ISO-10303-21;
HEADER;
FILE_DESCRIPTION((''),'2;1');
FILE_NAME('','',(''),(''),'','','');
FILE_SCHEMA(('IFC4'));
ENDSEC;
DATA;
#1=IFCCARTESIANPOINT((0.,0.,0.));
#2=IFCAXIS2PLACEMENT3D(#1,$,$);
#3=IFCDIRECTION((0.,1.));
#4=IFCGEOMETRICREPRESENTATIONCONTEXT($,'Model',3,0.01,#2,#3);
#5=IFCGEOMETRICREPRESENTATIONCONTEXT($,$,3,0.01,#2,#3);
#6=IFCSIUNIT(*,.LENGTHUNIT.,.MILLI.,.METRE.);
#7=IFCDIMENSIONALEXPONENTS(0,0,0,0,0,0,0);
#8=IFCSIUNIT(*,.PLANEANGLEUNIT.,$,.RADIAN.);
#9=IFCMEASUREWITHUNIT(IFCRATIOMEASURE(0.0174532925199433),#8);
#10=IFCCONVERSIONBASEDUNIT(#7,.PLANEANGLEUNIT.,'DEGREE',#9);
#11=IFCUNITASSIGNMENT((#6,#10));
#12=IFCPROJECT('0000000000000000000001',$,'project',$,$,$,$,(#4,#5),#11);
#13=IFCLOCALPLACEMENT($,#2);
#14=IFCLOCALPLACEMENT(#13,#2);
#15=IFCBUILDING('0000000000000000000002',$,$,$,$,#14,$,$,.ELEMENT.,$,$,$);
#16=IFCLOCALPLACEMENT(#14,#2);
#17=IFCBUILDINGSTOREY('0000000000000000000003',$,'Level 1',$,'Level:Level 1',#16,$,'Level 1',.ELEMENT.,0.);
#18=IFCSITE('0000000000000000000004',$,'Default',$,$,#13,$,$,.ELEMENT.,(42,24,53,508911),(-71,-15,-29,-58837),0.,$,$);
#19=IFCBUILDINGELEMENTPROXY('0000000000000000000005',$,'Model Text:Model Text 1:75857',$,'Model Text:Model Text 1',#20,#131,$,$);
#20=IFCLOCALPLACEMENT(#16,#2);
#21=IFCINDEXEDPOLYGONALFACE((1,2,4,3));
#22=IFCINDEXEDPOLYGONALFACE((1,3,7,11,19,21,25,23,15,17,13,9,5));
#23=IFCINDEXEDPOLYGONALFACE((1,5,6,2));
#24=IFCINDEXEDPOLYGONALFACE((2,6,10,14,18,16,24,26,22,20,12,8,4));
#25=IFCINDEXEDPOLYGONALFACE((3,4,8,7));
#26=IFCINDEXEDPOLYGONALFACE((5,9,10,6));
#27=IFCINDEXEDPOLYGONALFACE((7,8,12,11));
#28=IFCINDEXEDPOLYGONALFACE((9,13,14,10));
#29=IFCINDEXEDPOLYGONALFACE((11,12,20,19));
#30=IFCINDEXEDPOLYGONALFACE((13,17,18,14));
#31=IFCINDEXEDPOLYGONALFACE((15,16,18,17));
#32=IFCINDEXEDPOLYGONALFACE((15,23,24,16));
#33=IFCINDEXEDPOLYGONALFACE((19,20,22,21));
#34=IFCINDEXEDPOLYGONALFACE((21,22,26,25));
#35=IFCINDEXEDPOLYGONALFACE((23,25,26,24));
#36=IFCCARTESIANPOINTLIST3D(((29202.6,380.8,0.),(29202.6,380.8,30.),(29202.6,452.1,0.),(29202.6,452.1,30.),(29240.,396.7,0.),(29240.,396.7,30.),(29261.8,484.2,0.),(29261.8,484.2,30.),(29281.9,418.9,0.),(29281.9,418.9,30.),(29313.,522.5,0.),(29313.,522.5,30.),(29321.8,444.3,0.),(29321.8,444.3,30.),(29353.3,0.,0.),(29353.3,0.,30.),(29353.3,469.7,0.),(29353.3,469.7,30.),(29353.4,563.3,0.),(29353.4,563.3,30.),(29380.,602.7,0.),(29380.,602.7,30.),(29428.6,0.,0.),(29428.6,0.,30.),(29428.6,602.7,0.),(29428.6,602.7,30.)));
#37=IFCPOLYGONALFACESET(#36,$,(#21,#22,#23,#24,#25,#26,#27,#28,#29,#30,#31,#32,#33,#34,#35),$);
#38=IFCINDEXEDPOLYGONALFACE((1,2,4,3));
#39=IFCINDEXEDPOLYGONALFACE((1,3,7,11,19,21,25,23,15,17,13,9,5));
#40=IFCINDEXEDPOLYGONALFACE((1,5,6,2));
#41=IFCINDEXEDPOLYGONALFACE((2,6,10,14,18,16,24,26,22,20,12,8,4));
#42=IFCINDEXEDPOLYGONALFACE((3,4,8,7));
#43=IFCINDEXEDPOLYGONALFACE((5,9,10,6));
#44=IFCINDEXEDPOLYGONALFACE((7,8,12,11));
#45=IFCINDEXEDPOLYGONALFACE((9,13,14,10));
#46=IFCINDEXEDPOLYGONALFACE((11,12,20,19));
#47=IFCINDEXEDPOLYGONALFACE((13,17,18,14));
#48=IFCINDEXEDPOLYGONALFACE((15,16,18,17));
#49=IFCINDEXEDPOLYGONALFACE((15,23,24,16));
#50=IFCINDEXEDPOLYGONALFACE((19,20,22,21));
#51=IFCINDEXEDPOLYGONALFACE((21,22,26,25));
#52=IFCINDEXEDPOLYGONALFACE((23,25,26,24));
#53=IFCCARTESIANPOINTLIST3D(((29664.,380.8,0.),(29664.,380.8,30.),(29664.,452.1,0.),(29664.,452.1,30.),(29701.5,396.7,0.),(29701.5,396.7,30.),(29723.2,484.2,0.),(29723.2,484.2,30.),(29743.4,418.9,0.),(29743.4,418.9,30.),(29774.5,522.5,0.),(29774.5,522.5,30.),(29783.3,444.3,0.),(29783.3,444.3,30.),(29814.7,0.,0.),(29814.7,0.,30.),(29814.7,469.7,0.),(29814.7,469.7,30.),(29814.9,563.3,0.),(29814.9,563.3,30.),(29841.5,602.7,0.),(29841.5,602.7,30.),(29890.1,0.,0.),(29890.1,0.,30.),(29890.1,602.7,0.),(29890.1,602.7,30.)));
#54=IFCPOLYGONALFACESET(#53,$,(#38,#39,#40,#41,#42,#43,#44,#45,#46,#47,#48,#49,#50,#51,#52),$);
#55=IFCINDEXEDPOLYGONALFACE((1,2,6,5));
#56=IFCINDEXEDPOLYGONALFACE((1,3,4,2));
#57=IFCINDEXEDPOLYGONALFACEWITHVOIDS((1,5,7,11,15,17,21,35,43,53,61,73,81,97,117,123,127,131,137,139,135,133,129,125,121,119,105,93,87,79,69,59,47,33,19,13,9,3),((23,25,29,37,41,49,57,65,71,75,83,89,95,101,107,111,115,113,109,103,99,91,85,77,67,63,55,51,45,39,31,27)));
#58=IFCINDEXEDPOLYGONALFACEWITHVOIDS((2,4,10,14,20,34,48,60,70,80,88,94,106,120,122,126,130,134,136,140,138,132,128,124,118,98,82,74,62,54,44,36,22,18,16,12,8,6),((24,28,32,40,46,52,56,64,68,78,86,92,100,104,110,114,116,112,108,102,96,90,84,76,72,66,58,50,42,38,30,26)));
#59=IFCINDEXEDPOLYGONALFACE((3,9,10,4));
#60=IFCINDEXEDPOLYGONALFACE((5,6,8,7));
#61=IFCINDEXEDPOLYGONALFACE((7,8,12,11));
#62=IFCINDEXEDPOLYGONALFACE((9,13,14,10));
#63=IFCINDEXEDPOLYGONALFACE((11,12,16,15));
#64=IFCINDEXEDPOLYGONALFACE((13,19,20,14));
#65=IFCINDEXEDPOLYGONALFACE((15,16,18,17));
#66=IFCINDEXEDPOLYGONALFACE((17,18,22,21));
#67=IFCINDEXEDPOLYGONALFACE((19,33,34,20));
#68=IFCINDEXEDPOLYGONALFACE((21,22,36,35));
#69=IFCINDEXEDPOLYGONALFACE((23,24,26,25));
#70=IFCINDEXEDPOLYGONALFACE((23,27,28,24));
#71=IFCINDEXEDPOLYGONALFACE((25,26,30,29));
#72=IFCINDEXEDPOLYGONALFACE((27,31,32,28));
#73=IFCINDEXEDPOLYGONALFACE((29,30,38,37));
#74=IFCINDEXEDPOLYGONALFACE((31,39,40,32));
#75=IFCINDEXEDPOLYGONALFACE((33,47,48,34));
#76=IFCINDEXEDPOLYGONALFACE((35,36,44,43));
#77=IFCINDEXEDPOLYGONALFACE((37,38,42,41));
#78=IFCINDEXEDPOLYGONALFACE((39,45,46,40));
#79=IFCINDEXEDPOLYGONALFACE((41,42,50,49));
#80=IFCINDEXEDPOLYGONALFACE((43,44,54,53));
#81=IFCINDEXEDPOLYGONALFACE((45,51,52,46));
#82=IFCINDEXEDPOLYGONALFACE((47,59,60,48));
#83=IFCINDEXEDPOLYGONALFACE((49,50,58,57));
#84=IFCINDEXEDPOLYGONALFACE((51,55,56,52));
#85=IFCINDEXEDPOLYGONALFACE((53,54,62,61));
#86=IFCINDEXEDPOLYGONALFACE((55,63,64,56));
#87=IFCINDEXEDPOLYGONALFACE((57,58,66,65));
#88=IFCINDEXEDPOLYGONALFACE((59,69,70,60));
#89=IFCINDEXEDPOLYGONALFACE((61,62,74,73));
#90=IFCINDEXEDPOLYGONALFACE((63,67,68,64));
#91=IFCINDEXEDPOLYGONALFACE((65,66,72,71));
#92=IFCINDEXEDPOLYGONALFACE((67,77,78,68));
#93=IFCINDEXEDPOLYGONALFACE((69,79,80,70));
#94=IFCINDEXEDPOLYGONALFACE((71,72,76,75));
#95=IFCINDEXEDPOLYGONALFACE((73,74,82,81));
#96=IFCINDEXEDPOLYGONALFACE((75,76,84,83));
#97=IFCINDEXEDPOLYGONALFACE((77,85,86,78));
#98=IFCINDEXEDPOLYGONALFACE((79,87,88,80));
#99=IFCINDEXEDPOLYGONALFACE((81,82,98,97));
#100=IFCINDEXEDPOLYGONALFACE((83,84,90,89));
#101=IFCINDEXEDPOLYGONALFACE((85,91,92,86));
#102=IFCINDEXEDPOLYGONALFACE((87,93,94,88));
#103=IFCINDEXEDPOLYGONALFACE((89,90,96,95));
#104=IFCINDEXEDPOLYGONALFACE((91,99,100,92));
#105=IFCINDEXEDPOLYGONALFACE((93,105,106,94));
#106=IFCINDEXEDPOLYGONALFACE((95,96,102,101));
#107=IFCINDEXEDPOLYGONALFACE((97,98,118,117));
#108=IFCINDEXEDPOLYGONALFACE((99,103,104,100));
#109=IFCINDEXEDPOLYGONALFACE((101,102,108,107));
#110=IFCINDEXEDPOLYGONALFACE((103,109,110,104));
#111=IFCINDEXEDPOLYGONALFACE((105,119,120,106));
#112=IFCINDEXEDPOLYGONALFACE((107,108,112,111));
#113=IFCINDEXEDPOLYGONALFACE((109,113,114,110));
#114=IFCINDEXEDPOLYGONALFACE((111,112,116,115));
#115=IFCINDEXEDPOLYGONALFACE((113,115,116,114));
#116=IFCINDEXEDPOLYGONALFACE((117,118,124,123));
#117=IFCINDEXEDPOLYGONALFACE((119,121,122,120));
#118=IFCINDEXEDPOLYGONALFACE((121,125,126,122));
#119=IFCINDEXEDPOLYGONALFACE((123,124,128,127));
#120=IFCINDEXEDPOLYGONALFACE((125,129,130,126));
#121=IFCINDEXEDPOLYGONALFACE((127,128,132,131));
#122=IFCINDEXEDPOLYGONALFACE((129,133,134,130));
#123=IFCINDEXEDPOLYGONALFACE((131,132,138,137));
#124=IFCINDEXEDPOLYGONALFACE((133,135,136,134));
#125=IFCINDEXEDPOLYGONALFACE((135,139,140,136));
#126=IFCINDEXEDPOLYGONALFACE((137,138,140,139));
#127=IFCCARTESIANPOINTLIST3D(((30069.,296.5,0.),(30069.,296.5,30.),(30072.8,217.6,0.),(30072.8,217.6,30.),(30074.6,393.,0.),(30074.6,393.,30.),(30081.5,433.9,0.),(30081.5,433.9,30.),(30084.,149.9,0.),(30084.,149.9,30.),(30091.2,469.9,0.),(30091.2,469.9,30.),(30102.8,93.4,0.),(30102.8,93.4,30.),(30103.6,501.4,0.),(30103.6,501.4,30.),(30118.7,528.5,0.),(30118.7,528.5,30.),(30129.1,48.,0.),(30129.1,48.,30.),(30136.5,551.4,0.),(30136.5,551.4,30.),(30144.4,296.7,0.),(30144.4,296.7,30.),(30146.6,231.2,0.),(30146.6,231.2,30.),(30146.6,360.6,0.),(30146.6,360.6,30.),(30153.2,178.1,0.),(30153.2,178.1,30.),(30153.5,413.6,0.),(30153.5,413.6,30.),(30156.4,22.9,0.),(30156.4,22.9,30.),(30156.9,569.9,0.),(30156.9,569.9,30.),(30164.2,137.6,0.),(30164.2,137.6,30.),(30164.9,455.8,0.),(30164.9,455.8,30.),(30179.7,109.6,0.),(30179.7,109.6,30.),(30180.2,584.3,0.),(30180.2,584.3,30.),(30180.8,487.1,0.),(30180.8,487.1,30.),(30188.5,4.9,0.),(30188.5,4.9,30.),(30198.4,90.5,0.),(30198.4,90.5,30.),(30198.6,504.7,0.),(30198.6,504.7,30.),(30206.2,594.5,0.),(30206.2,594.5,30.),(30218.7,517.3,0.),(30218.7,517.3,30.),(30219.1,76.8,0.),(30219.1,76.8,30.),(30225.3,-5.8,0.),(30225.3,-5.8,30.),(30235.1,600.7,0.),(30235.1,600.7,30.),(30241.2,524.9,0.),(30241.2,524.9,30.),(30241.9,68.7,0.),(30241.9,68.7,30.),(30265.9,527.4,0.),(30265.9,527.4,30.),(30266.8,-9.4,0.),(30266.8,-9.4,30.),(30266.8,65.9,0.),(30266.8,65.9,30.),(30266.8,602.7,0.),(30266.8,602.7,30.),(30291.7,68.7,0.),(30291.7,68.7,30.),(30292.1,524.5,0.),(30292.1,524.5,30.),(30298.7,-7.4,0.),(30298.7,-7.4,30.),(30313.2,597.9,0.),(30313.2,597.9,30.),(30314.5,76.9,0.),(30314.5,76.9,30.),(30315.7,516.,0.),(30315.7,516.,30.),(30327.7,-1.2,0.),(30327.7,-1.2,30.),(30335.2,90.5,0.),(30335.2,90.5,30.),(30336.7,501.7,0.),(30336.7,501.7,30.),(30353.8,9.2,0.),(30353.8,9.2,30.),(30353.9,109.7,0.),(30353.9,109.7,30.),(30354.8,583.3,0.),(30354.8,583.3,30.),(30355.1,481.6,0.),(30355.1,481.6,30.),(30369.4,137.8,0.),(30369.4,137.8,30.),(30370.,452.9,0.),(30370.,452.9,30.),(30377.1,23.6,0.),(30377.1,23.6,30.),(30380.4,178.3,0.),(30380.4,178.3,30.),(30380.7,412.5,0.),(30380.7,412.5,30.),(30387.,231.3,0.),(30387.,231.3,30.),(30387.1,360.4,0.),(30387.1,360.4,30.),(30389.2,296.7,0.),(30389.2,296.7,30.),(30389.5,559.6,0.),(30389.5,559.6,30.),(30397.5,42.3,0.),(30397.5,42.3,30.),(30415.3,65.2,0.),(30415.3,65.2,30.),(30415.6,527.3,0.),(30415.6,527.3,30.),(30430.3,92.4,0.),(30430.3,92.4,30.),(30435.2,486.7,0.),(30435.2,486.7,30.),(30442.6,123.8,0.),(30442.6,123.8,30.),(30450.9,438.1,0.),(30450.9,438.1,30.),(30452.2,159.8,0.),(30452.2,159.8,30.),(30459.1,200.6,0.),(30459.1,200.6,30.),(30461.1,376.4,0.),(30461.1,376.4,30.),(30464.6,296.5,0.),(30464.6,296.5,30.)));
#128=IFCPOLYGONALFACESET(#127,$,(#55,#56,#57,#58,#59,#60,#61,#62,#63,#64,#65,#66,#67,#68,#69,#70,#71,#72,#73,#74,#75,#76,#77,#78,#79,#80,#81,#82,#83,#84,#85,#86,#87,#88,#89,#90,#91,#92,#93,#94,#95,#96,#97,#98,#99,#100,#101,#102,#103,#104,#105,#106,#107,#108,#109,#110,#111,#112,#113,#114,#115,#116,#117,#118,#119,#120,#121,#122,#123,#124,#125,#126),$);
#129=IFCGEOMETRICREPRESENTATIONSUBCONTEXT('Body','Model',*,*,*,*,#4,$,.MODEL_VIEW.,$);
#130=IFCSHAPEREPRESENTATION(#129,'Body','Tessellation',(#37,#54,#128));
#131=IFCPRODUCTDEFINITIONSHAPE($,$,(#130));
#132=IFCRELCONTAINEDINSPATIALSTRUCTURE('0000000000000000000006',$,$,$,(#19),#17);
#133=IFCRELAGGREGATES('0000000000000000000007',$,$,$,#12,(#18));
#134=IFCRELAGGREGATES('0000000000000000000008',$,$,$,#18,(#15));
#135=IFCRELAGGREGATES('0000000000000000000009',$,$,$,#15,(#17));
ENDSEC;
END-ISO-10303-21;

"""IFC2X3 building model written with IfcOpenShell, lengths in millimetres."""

from ifc_helpers import new_model, entity, si_unit, converted_unit, direction, frame, origin, place, context, subcontext, project, spatial, polyline, outline, extrude, element, save


model = new_model("IFC2X3")

# Units and contexts
model_context = context("Model", 3, precision=0.01, world=origin(), true_north=direction((0.0, 1.0)))
context_of_model = context(None, 3, precision=0.01, world=origin(), true_north=direction((0.0, 1.0)))
body_context = subcontext(model_context, "Body", "Model", "MODEL_VIEW")
ifc_project = project(units=[si_unit("LENGTHUNIT", "METRE", prefix="MILLI"), converted_unit("PLANEANGLEUNIT", "DEGREE", entity("IfcRatioMeasure", 0.0174532925199433), si_unit("PLANEANGLEUNIT", "RADIAN"), dimensions=[0, 0, 0, 0, 0, 0, 0])], contexts=[model_context, context_of_model])

# Site, building, storey
site_placement = place(None, origin())
site = spatial("IfcSite", under=ifc_project, at=site_placement, Name="Default", CompositionType="ELEMENT", RefLatitude=(42, 24, 53, 508911), RefLongitude=(-71, -15, -29, -58837), RefElevation=0.0)
building_placement = place(site_placement, origin())
building = spatial("IfcBuilding", under=site, at=building_placement, CompositionType="ELEMENT")
storey_placement = place(building_placement, origin())
storey = spatial("IfcBuildingStorey", under=building, at=storey_placement, Name="Level 1", ObjectType="Level:Level 1", LongName="Level 1", CompositionType="ELEMENT", Elevation=0.0)

# Building element proxy
proxy_1_placement = place(storey_placement, origin())
element("IfcBuildingElementProxy", 1, at=proxy_1_placement, inside=storey, Name="Model Text:Model Text 1:75857", ObjectType="Model Text:Model Text 1", context=body_context, shape_type="SweptSolid", body=[
    extrude(outline(polyline([(-410.6, -111.6), (192.1, -111.6), (192.1, -63.1), (152.7, -36.4), (111.9, 4.0), (73.6, 55.2), (41.4, 114.4), (-29.8, 114.4), (-13.9, 77.0), (8.3, 35.1), (33.7, -4.8), (59.1, -36.3), (-410.6, -36.3), (-410.6, -111.6)])), frame((29317.0, 410.6, 0.0), z_axis=(0.0, 0.0, 1.0), x_axis=(0.0, 1.0, 0.0)), (0.0, 0.0, 1.0), 30.0),
    extrude(outline(polyline([(-410.6, -111.6), (192.1, -111.6), (192.1, -63.1), (152.7, -36.4), (111.9, 4.0), (73.6, 55.2), (41.4, 114.4), (-29.8, 114.4), (-13.9, 77.0), (8.3, 35.1), (33.7, -4.8), (59.1, -36.3), (-410.6, -36.3), (-410.6, -111.6)])), frame((29778.5, 410.6, 0.0), z_axis=(0.0, 0.0, 1.0), x_axis=(0.0, 1.0, 0.0)), (0.0, 0.0, 1.0), 30.0),
    extrude(outline(polyline([(-10.6, -198.7), (68.3, -198.7), (136.5, -190.7), (193.9, -174.7), (240.5, -150.6), (266.9, -124.4), (286.3, -93.2), (298.8, -57.0), (304.3, -15.7), (303.8, 16.2), (299.0, 45.5), (289.9, 72.1), (276.6, 96.0), (258.9, 117.3), (236.9, 136.2), (210.4, 152.5), (179.6, 166.3), (144.1, 177.6), (103.7, 186.3), (8.2, 196.4), (-71.8, 196.7), (-134.0, 189.4), (-183.3, 176.1), (-224.7, 158.4), (-258.2, 133.9), (-283.5, 100.3), (-300.1, 59.5), (-307.1, 13.4), (-306.6, -18.4), (-301.8, -47.5), (-292.8, -74.0), (-279.6, -97.9), (-262.0, -119.2), (-240.0, -138.1), (-213.6, -154.5), (-182.8, -168.4), (-147.3, -179.8), (-106.7, -188.6), (-10.6, -198.7)]), holes=[polyline([(-7.2, -123.5), (-71.0, -118.2), (-123.6, -108.8), (-165.2, -95.4), (-195.7, -78.0), (-212.4, -59.4), (-224.1, -38.7), (-230.6, -15.9), (-231.9, 8.9), (-227.8, 35.0), (-218.1, 58.1), (-202.8, 78.4), (-182.0, 95.8), (-152.6, 109.4), (-111.7, 118.1), (-59.4, 122.0), (4.4, 121.1), (69.6, 115.8), (122.2, 106.7), (162.2, 93.7), (189.5, 77.0), (207.7, 57.4), (220.4, 36.0), (227.5, 12.8), (229.1, -12.1), (225.2, -36.8), (215.9, -59.2), (201.3, -79.3), (181.4, -97.1), (152.6, -111.2), (111.6, -120.3), (58.3, -124.4), (-7.2, -123.5)])]), frame((30268.0, 295.3, 0.0), z_axis=(0.0, 0.0, 1.0), x_axis=(0.047515, -0.998871, 0.0)), (0.0, 0.0, 1.0), 30.0),
])

save(model, "model.ifc")
